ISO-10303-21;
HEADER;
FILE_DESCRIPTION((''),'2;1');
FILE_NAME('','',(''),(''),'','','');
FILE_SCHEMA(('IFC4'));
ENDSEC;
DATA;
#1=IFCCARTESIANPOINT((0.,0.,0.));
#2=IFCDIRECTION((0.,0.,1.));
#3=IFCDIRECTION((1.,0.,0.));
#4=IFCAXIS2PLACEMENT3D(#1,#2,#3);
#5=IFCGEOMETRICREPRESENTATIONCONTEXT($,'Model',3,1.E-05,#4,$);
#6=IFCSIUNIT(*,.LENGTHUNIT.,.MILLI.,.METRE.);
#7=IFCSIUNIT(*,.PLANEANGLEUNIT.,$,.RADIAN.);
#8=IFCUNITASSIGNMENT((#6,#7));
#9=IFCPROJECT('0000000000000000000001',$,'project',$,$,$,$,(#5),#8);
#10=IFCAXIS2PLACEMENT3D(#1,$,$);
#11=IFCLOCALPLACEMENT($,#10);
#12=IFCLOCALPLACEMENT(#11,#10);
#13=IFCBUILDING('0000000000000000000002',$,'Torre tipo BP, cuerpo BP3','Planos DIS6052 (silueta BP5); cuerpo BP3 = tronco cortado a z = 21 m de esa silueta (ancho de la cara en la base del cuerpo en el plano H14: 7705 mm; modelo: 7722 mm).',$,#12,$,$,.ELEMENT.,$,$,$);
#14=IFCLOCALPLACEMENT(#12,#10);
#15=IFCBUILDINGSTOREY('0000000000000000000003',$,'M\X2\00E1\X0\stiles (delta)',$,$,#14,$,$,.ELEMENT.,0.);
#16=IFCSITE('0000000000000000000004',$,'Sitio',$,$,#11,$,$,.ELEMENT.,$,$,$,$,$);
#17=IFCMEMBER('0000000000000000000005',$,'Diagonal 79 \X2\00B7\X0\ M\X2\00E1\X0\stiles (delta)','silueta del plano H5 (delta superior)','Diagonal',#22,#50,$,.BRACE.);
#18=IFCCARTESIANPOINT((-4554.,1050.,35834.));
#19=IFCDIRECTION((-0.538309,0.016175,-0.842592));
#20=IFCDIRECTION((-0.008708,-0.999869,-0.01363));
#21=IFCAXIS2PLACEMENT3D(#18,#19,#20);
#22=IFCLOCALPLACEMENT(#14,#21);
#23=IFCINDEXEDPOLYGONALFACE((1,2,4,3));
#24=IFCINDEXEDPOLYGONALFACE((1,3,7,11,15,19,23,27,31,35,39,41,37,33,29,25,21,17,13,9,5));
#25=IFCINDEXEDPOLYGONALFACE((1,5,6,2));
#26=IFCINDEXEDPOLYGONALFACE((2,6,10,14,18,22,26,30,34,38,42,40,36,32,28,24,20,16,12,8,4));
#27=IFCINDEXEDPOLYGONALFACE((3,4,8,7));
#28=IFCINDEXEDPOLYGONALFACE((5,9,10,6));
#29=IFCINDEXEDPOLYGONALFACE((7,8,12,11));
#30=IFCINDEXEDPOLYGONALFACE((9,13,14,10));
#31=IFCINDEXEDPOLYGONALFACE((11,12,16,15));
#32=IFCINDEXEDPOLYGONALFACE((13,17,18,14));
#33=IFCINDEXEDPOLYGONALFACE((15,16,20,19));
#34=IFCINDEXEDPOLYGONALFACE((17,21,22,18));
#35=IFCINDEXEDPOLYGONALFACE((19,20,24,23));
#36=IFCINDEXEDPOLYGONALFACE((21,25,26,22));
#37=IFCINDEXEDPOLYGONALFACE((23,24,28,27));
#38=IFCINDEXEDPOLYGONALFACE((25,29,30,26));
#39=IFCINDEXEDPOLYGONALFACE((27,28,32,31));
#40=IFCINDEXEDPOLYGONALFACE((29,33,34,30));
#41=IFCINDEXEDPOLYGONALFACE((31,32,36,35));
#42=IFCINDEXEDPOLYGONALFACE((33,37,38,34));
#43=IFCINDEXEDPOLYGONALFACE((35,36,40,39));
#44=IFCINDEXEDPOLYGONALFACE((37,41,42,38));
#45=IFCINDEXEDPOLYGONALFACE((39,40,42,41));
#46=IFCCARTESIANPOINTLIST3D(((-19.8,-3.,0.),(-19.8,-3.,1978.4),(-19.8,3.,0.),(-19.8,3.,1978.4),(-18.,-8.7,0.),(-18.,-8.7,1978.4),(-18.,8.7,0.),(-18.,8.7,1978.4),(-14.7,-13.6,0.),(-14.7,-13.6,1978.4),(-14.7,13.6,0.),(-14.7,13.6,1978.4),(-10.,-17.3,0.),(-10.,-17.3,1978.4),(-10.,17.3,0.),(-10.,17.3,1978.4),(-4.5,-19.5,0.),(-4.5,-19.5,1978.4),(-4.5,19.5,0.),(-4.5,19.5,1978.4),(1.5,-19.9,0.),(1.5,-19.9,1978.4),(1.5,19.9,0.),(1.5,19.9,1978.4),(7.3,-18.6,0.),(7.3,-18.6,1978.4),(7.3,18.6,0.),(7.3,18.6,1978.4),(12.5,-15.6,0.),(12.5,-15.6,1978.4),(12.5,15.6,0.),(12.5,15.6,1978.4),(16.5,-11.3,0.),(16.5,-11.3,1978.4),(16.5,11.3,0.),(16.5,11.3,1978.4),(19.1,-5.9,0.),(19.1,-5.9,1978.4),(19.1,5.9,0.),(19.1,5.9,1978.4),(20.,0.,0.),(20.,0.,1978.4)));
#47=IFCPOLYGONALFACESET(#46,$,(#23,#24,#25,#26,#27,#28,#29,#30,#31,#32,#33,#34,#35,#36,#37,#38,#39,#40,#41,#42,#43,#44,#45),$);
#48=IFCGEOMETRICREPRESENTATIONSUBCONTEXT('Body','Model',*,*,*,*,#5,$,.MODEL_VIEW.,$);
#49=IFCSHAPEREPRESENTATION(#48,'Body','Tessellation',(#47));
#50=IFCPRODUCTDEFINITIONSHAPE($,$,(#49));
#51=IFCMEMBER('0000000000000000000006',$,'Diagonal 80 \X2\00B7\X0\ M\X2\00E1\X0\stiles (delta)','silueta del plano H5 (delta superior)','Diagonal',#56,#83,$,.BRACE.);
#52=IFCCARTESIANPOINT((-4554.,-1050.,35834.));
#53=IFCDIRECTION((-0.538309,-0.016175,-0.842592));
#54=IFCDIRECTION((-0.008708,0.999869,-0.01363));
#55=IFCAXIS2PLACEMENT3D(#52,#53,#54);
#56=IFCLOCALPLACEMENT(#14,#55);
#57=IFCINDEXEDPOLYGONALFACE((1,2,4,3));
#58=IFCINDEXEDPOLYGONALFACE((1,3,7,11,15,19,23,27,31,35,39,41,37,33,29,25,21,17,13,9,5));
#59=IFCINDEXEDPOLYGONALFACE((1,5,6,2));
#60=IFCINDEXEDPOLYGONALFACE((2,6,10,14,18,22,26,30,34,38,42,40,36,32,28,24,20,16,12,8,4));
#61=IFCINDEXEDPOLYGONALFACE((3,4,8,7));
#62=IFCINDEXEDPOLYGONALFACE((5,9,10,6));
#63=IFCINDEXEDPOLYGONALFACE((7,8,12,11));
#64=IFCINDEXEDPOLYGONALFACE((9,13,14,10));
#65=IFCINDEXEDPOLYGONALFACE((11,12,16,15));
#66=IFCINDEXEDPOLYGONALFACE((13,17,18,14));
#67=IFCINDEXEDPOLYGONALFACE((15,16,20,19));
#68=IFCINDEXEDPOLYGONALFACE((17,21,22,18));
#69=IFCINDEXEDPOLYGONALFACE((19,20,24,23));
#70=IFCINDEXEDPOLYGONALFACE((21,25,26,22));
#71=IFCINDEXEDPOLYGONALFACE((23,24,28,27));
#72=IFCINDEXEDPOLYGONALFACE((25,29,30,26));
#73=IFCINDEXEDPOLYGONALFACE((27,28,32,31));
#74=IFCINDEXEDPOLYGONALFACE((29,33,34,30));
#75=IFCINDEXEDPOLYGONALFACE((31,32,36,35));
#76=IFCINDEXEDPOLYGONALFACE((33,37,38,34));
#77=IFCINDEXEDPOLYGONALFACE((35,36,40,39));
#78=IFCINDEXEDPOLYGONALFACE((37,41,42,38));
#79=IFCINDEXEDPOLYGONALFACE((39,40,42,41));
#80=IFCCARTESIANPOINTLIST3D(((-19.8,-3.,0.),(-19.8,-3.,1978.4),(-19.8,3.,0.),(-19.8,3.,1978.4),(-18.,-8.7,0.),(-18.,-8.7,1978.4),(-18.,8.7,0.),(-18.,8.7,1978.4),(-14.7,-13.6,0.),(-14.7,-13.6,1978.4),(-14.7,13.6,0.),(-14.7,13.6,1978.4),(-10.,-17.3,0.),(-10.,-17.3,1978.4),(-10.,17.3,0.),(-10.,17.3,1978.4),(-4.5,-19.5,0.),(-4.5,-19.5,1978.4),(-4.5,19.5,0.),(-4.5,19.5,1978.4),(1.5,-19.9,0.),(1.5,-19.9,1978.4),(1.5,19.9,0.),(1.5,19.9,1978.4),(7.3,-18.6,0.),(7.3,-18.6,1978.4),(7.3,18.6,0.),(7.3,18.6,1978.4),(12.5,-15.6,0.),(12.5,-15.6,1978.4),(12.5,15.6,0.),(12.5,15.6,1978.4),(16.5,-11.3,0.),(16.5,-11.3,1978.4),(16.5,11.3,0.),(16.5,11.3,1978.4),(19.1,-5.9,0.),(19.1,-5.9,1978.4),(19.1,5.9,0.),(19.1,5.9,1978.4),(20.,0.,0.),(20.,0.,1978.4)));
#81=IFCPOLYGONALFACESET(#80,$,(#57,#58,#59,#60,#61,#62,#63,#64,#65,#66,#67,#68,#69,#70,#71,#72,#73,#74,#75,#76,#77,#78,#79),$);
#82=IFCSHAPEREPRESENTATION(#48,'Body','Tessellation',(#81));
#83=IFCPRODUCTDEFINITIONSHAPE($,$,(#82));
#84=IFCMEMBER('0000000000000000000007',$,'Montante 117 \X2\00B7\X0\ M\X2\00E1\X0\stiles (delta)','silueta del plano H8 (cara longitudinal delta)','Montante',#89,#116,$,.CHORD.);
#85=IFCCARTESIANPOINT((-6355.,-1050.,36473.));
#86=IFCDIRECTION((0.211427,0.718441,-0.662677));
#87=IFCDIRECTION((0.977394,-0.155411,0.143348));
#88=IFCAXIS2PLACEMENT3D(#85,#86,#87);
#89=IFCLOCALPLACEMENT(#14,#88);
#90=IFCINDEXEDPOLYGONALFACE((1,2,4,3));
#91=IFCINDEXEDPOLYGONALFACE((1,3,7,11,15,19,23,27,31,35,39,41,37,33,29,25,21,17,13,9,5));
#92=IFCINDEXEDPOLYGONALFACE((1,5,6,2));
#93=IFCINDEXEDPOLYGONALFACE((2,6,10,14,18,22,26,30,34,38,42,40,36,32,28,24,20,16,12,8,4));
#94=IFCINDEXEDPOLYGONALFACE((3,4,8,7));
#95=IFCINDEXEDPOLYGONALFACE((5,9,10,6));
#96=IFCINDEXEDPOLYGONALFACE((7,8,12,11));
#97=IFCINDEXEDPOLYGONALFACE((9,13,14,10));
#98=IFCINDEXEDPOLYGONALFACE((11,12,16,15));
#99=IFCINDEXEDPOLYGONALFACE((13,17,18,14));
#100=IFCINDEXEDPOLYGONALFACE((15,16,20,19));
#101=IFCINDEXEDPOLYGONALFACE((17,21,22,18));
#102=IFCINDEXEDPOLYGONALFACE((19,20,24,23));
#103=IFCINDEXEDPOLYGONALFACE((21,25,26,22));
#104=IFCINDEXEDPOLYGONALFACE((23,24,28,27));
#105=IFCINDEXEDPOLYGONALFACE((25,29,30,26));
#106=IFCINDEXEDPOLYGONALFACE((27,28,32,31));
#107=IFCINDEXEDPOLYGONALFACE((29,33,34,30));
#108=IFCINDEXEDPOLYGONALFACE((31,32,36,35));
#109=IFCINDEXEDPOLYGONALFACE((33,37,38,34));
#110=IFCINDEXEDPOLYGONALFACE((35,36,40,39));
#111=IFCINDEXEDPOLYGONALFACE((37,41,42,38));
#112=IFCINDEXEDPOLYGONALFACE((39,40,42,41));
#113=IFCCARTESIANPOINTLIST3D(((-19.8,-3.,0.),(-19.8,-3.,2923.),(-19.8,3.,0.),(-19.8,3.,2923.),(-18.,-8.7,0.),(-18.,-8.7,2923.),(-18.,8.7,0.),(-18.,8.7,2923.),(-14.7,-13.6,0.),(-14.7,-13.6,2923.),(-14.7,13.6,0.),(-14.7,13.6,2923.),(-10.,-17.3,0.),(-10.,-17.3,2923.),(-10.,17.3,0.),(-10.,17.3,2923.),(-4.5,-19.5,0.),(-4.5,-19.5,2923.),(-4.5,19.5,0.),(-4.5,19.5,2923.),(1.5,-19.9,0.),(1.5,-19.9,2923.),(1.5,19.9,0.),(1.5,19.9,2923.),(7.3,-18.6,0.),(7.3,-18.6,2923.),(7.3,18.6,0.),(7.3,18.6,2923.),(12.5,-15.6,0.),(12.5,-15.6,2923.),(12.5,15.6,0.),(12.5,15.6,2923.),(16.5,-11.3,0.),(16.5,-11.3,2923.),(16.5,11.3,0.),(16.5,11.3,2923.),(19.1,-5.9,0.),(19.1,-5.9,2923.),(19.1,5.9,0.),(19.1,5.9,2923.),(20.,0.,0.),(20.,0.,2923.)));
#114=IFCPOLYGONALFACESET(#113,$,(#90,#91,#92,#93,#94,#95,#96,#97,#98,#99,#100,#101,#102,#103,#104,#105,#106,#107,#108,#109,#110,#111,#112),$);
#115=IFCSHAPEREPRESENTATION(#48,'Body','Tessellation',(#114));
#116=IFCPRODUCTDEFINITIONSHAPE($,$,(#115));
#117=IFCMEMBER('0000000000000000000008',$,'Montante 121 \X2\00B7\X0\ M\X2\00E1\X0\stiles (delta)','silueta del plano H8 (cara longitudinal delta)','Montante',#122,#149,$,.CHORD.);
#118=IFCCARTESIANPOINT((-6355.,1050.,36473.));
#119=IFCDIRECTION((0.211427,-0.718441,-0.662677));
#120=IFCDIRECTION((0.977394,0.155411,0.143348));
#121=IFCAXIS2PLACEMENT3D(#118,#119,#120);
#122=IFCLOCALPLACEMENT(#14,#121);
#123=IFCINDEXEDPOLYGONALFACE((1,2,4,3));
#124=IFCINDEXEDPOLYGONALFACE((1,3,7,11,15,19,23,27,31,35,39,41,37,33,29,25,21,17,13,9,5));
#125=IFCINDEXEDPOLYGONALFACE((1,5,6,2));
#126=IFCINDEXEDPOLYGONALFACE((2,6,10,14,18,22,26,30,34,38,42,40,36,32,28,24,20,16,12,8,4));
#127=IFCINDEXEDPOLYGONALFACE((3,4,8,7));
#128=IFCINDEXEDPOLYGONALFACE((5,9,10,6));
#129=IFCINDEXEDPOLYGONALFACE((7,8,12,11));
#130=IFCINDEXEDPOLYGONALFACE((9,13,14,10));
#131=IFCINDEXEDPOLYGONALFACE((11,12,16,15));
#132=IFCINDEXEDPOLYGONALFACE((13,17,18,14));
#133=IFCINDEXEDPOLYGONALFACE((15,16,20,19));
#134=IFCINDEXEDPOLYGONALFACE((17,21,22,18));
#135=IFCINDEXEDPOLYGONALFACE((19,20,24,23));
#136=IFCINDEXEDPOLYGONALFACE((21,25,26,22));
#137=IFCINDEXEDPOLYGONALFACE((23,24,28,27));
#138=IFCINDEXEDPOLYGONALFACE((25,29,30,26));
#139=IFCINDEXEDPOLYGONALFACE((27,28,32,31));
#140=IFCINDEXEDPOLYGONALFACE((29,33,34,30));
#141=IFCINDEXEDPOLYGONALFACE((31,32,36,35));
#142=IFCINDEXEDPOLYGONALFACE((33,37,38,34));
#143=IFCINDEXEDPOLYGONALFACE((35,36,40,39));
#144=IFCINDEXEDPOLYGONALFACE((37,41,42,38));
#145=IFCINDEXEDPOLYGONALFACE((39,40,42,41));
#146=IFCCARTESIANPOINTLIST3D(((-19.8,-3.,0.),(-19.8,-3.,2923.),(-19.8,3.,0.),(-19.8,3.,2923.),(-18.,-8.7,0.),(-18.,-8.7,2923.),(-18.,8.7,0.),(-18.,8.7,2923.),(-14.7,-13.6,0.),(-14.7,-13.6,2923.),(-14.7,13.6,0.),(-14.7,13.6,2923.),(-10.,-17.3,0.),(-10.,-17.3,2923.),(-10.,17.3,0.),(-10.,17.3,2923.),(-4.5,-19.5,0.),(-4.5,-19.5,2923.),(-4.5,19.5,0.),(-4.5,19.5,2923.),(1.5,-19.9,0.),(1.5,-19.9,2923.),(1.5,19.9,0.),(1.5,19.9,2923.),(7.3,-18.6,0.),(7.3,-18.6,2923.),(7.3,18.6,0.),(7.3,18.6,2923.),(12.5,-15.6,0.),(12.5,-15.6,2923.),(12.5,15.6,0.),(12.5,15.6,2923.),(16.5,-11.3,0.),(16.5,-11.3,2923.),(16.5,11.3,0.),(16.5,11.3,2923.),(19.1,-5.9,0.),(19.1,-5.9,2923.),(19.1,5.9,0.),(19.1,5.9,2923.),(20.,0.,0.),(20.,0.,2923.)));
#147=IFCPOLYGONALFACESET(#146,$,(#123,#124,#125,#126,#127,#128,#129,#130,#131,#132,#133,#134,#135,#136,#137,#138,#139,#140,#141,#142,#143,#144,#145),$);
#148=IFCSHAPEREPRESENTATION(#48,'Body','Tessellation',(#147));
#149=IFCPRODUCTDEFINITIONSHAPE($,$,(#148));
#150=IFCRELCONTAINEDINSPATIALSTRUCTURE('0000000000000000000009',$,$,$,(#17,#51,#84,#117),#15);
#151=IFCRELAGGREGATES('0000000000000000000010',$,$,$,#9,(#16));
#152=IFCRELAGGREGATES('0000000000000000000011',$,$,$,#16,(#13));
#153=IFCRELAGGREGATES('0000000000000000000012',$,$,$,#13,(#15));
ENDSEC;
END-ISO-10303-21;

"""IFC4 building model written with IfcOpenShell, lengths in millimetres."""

from ifc_helpers import new_model, si_unit, frame, origin, origin_with_axes, place, context, subcontext, project, spatial, circle, extrude, element, save


model = new_model("IFC4")

# Units and contexts
model_context = context("Model", 3, precision=1e-05, world=origin_with_axes())
body_context = subcontext(model_context, "Body", "Model", "MODEL_VIEW")
ifc_project = project(units=[si_unit("LENGTHUNIT", "METRE", prefix="MILLI"), si_unit("PLANEANGLEUNIT", "RADIAN")], contexts=[model_context])

# Site, building, storey
site_placement = place(None, origin())
site = spatial("IfcSite", under=ifc_project, at=site_placement, Name="Sitio", CompositionType="ELEMENT")
building_placement = place(site_placement, origin())
building = spatial("IfcBuilding", under=site, at=building_placement, Name="Torre tipo BP, cuerpo BP3", Description="Planos DIS6052 (silueta BP5); cuerpo BP3 = tronco cortado a z = 21 m de esa silueta (ancho de la cara en la base del cuerpo en el plano H14: 7705 mm; modelo: 7722 mm).", CompositionType="ELEMENT")
storey_placement = place(building_placement, origin())
storey = spatial("IfcBuildingStorey", under=building, at=storey_placement, Name="Mástiles (delta)", CompositionType="ELEMENT", Elevation=0.0)

# Members
for number, where, z_axis, x_axis, name in (
    (1, (-4554.0, 1050.0, 35834.0), (-0.538309, 0.016175, -0.842592), (-0.008708, -0.999869, -0.01363), "Diagonal 79 · Mástiles (delta)"),
    (2, (-4554.0, -1050.0, 35834.0), (-0.538309, -0.016175, -0.842592), (-0.008708, 0.999869, -0.01363), "Diagonal 80 · Mástiles (delta)"),
):
    element("IfcMember", number, at=place(storey_placement, frame(where, z_axis=z_axis, x_axis=x_axis)), inside=storey, Name=name, Description="silueta del plano H5 (delta superior)", ObjectType="Diagonal", PredefinedType="BRACE", context=body_context, shape_type="SweptSolid", body=[
        extrude(circle(Radius=20.0), None, (0.0, 0.0, 1.0), 1978.4),
    ])
member_1_placement = place(storey_placement, frame((-6355.0, -1050.0, 36473.0), z_axis=(0.211427, 0.718441, -0.662677), x_axis=(0.977394, -0.155411, 0.143348)))
element("IfcMember", 3, at=member_1_placement, inside=storey, Name="Montante 117 · Mástiles (delta)", Description="silueta del plano H8 (cara longitudinal delta)", ObjectType="Montante", PredefinedType="CHORD", context=body_context, shape_type="SweptSolid", body=[
    extrude(circle(Radius=20.0), None, (0.0, 0.0, 1.0), 2923.0),
])
member_2_placement = place(storey_placement, frame((-6355.0, 1050.0, 36473.0), z_axis=(0.211427, -0.718441, -0.662677), x_axis=(0.977394, 0.155411, 0.143348)))
element("IfcMember", 4, at=member_2_placement, inside=storey, Name="Montante 121 · Mástiles (delta)", Description="silueta del plano H8 (cara longitudinal delta)", ObjectType="Montante", PredefinedType="CHORD", context=body_context, shape_type="SweptSolid", body=[
    extrude(circle(Radius=20.0), None, (0.0, 0.0, 1.0), 2923.0),
])

save(model, "model.ifc")
